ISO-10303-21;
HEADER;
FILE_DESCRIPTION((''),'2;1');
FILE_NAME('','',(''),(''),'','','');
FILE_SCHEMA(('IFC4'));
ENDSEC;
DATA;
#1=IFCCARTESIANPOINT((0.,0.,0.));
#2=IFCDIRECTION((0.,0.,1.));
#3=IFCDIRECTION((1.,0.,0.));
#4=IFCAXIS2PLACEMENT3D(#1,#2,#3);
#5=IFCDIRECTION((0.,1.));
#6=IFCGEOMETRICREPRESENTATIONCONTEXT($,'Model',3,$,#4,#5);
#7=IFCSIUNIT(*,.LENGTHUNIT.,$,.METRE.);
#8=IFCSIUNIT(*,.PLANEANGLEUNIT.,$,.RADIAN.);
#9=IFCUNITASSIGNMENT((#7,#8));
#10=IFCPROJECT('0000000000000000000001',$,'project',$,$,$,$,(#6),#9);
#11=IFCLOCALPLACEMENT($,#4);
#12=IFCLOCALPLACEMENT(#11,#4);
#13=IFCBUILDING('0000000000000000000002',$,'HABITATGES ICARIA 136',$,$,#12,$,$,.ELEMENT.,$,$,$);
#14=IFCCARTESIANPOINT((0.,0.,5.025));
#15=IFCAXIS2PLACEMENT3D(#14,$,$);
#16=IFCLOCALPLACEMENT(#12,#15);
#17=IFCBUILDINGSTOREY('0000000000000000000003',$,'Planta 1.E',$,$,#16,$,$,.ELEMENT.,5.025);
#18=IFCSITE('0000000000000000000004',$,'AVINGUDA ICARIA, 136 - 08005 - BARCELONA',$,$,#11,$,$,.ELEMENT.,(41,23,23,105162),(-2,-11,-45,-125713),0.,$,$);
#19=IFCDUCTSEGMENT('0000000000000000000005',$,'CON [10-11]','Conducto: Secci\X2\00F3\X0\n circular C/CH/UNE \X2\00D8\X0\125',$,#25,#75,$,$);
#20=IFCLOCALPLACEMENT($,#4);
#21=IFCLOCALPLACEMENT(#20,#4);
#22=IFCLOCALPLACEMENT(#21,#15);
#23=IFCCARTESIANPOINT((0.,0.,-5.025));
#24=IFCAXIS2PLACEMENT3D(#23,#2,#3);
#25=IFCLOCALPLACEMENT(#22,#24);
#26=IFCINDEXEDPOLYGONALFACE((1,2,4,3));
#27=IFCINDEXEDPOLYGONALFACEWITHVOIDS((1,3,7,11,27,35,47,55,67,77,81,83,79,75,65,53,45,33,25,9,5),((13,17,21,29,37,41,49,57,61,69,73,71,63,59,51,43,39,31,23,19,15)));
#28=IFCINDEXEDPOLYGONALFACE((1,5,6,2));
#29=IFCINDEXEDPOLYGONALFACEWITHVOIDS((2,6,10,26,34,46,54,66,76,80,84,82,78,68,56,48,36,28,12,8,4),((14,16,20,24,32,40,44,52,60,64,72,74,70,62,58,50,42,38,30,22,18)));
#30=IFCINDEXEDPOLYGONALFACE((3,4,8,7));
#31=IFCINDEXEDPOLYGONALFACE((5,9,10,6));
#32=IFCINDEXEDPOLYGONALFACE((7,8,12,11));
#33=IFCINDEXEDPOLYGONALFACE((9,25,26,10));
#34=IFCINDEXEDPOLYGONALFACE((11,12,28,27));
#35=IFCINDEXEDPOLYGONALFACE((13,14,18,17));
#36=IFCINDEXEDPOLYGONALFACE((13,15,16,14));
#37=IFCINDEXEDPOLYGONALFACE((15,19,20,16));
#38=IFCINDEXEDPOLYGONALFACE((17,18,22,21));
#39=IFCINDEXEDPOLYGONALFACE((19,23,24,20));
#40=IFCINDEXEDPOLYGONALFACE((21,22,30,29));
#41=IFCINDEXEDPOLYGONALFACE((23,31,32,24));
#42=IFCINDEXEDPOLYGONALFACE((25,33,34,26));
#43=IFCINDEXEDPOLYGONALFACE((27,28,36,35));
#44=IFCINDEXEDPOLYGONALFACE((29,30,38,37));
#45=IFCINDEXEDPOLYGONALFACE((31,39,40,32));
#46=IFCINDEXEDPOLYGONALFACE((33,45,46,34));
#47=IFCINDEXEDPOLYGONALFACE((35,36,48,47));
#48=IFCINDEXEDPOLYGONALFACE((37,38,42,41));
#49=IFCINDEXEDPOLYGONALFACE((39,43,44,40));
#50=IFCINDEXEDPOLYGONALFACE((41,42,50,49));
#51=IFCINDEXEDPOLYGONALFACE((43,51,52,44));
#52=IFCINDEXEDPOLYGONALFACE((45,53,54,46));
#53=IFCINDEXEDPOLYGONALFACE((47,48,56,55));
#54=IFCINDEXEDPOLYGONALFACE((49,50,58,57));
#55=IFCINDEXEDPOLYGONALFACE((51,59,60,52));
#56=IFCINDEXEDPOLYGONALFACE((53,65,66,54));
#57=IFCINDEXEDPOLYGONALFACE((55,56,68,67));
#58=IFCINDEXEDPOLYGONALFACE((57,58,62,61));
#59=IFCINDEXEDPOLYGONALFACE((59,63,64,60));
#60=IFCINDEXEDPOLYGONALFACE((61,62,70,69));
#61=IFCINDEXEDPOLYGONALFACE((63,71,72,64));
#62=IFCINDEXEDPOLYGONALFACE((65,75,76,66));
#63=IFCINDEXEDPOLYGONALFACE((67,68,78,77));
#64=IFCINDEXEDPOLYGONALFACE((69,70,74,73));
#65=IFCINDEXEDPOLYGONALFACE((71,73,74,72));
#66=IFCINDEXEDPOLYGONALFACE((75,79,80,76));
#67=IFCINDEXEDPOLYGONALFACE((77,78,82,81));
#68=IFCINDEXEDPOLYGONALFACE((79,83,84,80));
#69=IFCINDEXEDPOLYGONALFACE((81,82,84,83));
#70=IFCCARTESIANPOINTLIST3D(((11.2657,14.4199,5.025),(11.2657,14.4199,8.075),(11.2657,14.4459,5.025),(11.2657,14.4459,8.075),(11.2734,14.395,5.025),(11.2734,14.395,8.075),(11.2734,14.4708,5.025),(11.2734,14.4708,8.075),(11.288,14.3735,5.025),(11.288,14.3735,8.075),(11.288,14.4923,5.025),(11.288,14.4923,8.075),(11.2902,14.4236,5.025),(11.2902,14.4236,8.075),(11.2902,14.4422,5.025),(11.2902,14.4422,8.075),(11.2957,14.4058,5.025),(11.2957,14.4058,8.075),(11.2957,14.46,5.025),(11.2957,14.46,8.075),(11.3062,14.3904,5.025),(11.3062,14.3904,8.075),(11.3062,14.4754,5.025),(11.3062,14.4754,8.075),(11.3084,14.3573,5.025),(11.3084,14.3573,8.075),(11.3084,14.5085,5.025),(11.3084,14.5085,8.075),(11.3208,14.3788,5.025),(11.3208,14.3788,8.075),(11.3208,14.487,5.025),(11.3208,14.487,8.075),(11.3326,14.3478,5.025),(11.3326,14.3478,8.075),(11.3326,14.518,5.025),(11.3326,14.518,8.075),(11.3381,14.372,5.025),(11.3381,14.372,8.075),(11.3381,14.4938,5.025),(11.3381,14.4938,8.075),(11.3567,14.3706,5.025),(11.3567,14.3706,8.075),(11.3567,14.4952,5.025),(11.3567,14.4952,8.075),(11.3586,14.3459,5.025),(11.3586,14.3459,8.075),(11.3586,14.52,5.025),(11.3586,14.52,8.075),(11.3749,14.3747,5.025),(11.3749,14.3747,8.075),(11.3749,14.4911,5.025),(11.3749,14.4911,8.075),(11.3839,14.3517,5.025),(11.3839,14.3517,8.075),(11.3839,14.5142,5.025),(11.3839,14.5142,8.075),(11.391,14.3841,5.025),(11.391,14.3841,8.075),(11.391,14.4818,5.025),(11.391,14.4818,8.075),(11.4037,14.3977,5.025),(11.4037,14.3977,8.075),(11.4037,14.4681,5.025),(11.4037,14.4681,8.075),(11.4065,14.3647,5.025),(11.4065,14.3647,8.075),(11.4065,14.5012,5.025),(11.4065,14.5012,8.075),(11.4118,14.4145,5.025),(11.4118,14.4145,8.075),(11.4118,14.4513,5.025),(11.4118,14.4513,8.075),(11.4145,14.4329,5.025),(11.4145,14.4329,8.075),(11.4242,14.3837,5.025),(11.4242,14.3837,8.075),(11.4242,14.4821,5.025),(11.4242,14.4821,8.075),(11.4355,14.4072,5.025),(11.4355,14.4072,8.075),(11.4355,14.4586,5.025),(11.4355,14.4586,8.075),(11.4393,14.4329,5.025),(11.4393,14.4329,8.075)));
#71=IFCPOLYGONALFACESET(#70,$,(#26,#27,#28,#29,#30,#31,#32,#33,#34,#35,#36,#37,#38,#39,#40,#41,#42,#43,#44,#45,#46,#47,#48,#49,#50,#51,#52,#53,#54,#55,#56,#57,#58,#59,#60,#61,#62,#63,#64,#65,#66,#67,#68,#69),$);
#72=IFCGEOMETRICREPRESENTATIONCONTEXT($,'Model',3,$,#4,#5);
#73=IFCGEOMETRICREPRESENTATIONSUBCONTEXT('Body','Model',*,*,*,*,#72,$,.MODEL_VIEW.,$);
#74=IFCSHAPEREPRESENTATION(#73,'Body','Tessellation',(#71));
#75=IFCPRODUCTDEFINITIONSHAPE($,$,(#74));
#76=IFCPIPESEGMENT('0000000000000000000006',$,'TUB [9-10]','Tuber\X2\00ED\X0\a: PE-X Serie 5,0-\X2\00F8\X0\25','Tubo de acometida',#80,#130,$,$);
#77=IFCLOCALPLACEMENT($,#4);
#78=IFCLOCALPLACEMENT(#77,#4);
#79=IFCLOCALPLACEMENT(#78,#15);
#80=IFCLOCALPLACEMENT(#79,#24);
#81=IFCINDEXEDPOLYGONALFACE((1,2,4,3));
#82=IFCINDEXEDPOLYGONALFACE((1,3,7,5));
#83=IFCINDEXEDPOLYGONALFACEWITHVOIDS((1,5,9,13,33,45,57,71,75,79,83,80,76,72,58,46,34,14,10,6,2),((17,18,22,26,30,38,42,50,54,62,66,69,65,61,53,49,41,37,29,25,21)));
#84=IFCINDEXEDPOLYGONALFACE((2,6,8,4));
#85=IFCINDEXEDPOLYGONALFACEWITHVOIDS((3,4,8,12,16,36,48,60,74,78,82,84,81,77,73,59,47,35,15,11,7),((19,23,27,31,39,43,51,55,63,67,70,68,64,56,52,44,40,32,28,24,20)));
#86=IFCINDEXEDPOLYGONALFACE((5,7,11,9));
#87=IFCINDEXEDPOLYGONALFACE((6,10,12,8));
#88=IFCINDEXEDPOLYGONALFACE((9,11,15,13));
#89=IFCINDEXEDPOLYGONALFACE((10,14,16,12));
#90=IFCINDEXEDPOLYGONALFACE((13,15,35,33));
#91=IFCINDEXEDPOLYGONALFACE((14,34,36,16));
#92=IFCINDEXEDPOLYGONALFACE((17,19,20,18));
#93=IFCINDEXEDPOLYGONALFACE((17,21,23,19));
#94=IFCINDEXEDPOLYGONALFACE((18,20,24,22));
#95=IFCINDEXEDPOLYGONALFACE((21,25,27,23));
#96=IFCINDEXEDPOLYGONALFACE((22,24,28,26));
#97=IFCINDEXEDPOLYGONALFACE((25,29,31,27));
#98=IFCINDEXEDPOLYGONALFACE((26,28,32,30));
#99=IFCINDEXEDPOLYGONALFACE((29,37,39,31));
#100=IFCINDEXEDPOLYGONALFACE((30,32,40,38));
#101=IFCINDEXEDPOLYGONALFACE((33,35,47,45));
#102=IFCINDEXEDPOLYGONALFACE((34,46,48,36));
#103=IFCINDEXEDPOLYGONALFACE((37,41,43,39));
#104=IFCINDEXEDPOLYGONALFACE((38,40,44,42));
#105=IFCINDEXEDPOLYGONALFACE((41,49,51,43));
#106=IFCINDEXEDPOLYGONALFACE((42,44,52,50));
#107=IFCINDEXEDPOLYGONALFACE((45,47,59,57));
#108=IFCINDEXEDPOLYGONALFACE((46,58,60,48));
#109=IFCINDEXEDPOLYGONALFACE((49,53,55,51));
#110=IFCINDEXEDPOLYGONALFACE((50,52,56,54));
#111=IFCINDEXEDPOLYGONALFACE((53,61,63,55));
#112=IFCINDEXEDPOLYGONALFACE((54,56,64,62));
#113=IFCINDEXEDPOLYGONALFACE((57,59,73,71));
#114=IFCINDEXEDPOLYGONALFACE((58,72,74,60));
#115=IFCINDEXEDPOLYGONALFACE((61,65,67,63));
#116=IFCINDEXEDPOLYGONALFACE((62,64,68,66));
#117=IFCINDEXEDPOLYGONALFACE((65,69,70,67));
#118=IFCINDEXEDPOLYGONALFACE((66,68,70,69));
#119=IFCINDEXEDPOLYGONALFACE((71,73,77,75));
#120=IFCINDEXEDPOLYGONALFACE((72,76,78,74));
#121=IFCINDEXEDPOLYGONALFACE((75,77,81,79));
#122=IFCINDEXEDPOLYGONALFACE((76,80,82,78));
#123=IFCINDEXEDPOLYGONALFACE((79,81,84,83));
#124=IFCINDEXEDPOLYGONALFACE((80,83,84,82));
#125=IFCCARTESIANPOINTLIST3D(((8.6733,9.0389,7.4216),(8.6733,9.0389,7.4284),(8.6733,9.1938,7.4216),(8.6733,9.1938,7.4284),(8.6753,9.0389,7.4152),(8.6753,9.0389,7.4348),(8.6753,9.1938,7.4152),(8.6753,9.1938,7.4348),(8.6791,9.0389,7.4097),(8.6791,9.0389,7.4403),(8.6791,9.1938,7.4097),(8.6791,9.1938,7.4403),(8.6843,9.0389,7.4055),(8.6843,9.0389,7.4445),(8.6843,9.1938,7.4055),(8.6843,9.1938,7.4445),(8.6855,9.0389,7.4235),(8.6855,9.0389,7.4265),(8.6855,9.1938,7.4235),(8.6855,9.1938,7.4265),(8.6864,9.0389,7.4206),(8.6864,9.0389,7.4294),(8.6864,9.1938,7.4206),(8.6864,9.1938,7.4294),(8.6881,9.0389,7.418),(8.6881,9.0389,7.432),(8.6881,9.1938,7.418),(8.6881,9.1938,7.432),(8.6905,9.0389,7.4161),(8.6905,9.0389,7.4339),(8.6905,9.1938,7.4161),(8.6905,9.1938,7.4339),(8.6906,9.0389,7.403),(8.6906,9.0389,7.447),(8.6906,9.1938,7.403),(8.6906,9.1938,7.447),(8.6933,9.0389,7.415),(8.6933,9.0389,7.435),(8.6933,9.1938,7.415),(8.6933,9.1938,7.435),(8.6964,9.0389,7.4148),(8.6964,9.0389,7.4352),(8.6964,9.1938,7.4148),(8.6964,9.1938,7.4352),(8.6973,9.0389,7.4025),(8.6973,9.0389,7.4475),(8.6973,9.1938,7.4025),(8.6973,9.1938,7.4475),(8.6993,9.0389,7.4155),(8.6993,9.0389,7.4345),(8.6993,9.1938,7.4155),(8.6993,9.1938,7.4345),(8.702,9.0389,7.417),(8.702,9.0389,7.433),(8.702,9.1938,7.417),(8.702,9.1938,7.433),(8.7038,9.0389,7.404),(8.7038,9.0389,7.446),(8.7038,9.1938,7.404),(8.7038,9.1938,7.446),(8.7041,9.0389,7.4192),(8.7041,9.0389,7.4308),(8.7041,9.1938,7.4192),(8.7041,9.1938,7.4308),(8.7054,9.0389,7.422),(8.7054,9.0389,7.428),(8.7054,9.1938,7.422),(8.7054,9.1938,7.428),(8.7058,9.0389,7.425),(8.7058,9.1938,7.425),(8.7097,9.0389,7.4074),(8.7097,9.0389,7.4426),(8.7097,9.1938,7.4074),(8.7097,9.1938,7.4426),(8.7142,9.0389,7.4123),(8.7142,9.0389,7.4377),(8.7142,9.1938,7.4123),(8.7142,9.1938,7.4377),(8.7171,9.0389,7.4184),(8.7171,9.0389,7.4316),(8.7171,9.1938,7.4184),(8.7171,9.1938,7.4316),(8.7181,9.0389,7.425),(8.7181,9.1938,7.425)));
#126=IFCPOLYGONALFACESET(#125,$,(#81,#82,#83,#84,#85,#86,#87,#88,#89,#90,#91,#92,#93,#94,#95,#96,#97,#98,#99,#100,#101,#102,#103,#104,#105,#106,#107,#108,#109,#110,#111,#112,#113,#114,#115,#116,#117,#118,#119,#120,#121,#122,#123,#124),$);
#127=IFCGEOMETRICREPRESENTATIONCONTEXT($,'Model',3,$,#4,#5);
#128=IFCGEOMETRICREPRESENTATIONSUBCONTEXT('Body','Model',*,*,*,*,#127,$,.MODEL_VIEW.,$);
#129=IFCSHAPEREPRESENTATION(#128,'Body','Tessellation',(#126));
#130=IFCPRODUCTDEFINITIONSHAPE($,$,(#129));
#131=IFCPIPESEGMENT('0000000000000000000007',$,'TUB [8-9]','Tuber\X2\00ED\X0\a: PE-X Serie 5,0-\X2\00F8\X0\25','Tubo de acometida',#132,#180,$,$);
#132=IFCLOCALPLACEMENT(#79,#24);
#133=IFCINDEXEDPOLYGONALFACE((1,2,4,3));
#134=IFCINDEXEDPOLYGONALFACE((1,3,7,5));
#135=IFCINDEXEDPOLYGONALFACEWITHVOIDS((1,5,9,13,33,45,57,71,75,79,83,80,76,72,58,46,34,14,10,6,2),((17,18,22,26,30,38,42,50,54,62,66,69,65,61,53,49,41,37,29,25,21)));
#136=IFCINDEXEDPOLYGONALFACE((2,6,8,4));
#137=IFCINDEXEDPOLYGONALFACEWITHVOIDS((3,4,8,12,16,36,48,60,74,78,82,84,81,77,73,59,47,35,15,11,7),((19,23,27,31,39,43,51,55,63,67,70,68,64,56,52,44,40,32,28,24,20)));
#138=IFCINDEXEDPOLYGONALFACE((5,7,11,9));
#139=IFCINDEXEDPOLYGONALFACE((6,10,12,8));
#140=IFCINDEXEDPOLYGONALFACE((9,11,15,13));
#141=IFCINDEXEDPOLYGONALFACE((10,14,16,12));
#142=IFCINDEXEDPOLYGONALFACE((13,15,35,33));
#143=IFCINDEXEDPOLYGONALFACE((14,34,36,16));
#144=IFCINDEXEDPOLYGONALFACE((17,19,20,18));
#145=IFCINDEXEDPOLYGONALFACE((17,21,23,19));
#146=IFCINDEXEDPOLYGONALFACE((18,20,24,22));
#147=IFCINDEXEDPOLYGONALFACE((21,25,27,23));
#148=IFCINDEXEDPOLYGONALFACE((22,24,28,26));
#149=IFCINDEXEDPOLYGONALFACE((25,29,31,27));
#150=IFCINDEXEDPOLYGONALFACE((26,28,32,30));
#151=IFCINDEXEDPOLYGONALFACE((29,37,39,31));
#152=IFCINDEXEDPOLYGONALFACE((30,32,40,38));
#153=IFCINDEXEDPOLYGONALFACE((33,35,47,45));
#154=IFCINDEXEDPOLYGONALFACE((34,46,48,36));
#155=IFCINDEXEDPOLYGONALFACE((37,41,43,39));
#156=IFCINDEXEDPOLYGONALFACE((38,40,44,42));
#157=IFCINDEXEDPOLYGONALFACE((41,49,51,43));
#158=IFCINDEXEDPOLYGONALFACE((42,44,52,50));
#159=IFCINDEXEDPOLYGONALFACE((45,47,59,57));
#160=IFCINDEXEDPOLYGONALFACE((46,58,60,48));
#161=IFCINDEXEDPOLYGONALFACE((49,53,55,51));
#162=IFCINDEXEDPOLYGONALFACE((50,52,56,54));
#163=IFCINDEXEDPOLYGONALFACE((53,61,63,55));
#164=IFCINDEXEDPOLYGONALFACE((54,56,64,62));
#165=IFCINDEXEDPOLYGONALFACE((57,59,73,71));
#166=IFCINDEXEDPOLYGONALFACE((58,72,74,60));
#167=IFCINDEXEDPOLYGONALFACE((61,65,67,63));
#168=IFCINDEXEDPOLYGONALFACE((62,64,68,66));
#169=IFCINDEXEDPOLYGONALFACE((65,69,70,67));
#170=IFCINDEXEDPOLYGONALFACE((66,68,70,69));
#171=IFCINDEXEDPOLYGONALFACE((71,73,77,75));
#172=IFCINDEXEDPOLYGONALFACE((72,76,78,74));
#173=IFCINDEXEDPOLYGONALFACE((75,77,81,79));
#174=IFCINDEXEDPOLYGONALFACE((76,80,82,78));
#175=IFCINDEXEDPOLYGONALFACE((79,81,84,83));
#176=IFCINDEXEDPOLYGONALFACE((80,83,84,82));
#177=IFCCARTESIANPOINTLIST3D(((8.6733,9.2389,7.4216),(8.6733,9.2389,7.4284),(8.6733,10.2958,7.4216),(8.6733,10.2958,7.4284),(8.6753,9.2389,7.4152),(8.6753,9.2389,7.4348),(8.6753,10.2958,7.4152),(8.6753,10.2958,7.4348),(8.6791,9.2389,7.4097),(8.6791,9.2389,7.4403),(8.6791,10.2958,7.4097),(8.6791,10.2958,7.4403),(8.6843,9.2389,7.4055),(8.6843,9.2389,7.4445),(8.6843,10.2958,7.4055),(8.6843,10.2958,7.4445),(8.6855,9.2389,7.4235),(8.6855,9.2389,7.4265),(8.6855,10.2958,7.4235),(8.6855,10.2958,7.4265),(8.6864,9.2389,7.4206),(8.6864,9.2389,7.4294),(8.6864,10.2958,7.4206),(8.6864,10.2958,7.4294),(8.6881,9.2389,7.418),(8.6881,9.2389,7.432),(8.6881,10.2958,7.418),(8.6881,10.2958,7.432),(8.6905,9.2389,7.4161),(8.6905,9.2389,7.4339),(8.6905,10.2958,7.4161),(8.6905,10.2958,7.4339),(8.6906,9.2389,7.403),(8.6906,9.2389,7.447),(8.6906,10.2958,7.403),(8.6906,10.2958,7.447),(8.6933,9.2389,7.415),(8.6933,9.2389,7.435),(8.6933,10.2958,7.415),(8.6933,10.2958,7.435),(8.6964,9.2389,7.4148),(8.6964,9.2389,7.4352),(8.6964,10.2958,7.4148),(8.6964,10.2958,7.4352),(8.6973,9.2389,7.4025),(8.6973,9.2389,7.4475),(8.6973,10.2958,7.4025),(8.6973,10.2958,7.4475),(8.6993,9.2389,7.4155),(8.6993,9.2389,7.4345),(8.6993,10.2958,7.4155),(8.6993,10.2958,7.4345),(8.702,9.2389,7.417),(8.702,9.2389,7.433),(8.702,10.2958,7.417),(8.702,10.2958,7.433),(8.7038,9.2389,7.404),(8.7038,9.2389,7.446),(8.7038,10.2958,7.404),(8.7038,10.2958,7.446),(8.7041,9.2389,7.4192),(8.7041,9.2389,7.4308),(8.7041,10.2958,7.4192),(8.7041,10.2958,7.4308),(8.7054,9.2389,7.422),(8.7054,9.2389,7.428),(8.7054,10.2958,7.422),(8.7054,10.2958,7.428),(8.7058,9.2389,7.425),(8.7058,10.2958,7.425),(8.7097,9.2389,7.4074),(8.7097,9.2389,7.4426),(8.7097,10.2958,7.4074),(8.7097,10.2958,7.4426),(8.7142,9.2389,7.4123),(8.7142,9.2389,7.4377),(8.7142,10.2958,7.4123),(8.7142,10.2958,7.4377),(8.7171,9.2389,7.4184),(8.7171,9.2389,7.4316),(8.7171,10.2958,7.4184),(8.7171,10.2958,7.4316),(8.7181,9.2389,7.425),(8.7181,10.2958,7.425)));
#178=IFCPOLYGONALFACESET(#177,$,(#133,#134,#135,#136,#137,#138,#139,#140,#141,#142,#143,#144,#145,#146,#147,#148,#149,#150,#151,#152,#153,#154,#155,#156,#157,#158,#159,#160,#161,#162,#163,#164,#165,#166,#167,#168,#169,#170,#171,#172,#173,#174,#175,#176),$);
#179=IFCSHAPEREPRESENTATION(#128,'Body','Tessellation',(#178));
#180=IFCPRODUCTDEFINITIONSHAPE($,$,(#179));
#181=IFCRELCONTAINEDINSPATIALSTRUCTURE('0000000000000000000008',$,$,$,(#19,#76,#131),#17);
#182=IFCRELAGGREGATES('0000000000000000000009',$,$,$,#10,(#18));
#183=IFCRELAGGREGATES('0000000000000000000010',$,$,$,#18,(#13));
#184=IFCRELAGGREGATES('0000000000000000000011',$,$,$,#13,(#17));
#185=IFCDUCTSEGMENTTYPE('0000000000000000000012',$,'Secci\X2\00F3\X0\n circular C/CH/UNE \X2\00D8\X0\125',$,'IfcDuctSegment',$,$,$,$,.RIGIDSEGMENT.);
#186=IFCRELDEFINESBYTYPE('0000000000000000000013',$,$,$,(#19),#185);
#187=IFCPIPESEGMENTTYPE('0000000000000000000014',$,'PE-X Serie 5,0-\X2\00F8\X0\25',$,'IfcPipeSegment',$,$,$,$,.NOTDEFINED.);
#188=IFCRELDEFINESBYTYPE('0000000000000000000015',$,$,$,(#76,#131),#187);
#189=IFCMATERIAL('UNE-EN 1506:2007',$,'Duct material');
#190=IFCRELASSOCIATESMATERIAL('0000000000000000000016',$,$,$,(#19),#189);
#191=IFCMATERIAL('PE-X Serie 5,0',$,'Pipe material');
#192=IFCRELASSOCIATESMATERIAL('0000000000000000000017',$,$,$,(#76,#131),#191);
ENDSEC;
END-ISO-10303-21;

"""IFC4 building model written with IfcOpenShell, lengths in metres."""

from ifc_helpers import new_model, si_unit, direction, frame, origin_with_axes, origin_2d_with_axis, place, context, subcontext, project, spatial, hollow_circle, extrude, material, type_object, element, save


model = new_model("IFC4")

# Units and contexts
model_context_1 = context("Model", 3, world=origin_with_axes(), true_north=direction((0.0, 1.0)))
model_context_2 = context("Model", 3, world=origin_with_axes(), true_north=direction((0.0, 1.0)))
model_context_3 = context("Model", 3, world=origin_with_axes(), true_north=direction((0.0, 1.0)))
body_context_1 = subcontext(model_context_2, "Body", "Model", "MODEL_VIEW")
body_context_2 = subcontext(model_context_3, "Body", "Model", "MODEL_VIEW")
ifc_project = project(units=[si_unit("LENGTHUNIT", "METRE"), si_unit("PLANEANGLEUNIT", "RADIAN")], contexts=[model_context_1])

# Site, building, storey
site_placement = place(None, origin_with_axes())
site = spatial("IfcSite", under=ifc_project, at=site_placement, Name="AVINGUDA ICARIA, 136 - 08005 - BARCELONA", CompositionType="ELEMENT", RefLatitude=(41, 23, 23, 105162), RefLongitude=(-2, -11, -45, -125713), RefElevation=0.0)
building_placement = place(site_placement, origin_with_axes())
building = spatial("IfcBuilding", under=site, at=building_placement, Name="HABITATGES ICARIA 136", CompositionType="ELEMENT")
storey_placement = place(building_placement, frame((0.0, 0.0, 5.025)))
storey = spatial("IfcBuildingStorey", under=building, at=storey_placement, Name="Planta 1.E", CompositionType="ELEMENT", Elevation=5.025)

# Duct segment
ifc_material_1 = material(Name="UNE-EN 1506:2007", Category="Duct material")
duct_segment_type = type_object("IfcDuctSegmentType", Name="Sección circular C/CH/UNE Ø125", ApplicableOccurrence="IfcDuctSegment", PredefinedType="RIGIDSEGMENT")
placement_1 = place(None, origin_with_axes())
placement_2 = place(placement_1, origin_with_axes())
placement_3 = place(placement_2, frame((0.0, 0.0, 5.025)))
duct_segment_placement = place(placement_3, frame((0.0, 0.0, -5.025), z_axis=(0.0, 0.0, 1.0), x_axis=(1.0, 0.0, 0.0)))
element("IfcDuctSegment", 1, at=duct_segment_placement, inside=storey, type_object=duct_segment_type, material=ifc_material_1, Name="CON [10-11]", Description="Conducto: Sección circular C/CH/UNE Ø125", context=body_context_1, shape_type="SweptSolid", body=[
    extrude(hollow_circle(Radius=0.0873, WallThickness=0.0248, at=origin_2d_with_axis()), frame((11.352, 14.4329, 8.075), z_axis=(0.0, 0.0, -1.0), x_axis=(1.0, 0.0, 0.0)), (0.0, 0.0, 1.0), 3.05),
])

# Shared definitions
ifc_material_2 = material(Name="PE-X Serie 5,0", Category="Pipe material")
placement_4 = place(None, origin_with_axes())
placement_5 = place(placement_4, origin_with_axes())
placement_6 = place(placement_5, frame((0.0, 0.0, 5.025)))

# Pipe segments
pipe_segment_type_1 = type_object("IfcPipeSegmentType", Name="PE-X Serie 5,0-ø25", ApplicableOccurrence="IfcPipeSegment", PredefinedType="NOTDEFINED")
pipe_segment_1_placement = place(placement_6, frame((0.0, 0.0, -5.025), z_axis=(0.0, 0.0, 1.0), x_axis=(1.0, 0.0, 0.0)))
element("IfcPipeSegment", 2, at=pipe_segment_1_placement, inside=storey, type_object=pipe_segment_type_1, material=ifc_material_2, Name="TUB [9-10]", Description="Tubería: PE-X Serie 5,0-ø25", ObjectType="Tubo de acometida", context=body_context_2, shape_type="SweptSolid", body=[
    extrude(hollow_circle(Radius=0.0226, WallThickness=0.0123, at=origin_2d_with_axis()), frame((8.6956, 9.1938, 7.425), z_axis=(0.0, -1.0, 0.0), x_axis=(1.0, 0.0, 0.0)), (0.0, 0.0, 1.0), 0.1549),
])
pipe_segment_2_placement = place(placement_6, frame((0.0, 0.0, -5.025), z_axis=(0.0, 0.0, 1.0), x_axis=(1.0, 0.0, 0.0)))
element("IfcPipeSegment", 3, at=pipe_segment_2_placement, inside=storey, type_object=pipe_segment_type_1, material=ifc_material_2, Name="TUB [8-9]", Description="Tubería: PE-X Serie 5,0-ø25", ObjectType="Tubo de acometida", context=body_context_2, shape_type="SweptSolid", body=[
    extrude(hollow_circle(Radius=0.0226, WallThickness=0.0123, at=origin_2d_with_axis()), frame((8.6956, 10.2958, 7.425), z_axis=(0.0, -1.0, 0.0), x_axis=(1.0, 0.0, 0.0)), (0.0, 0.0, 1.0), 1.057),
])

save(model, "model.ifc")
